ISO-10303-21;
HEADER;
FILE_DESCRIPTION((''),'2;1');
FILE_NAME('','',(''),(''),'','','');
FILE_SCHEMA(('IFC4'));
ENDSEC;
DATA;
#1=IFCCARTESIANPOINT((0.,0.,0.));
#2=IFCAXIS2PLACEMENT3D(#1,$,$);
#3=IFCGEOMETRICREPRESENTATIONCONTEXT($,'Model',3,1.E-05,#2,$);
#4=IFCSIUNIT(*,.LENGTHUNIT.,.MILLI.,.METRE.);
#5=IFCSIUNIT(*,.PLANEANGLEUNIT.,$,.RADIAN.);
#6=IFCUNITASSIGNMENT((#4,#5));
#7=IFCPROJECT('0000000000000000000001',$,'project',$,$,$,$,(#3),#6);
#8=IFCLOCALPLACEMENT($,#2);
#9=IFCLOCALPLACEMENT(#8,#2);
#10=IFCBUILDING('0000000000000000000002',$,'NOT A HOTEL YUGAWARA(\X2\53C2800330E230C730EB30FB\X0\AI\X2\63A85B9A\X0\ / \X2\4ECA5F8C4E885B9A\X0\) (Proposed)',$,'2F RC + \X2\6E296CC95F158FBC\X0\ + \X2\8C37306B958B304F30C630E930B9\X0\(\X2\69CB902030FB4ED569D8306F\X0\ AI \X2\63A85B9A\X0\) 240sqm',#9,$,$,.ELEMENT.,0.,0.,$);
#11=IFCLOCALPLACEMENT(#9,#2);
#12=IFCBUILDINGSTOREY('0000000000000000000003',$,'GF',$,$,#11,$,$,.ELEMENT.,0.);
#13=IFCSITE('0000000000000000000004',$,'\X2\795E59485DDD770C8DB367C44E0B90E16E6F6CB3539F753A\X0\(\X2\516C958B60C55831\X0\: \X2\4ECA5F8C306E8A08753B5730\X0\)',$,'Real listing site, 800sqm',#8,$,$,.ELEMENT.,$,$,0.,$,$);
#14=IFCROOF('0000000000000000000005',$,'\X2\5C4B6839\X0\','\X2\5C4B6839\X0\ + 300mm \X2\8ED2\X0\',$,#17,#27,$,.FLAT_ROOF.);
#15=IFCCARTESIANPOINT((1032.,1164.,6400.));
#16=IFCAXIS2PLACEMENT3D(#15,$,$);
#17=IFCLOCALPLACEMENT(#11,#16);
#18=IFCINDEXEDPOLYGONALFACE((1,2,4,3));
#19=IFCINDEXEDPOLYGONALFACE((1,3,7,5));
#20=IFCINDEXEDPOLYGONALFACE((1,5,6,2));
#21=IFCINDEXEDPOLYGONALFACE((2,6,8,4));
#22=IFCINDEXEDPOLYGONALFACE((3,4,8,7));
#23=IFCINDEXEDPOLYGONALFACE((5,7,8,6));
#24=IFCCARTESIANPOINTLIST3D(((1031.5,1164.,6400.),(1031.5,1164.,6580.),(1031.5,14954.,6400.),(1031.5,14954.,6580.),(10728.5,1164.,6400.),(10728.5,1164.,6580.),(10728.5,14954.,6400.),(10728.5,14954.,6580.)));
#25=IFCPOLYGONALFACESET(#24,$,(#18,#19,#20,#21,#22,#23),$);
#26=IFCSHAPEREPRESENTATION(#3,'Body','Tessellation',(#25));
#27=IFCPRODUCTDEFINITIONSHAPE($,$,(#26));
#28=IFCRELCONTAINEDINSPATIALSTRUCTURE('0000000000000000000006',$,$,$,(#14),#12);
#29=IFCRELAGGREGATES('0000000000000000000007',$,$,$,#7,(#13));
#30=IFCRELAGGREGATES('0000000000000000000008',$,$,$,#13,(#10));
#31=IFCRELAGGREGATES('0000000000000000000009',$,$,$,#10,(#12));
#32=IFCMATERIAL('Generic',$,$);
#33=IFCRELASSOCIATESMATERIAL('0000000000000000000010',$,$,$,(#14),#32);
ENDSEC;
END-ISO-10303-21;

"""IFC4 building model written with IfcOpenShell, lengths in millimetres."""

from ifc_helpers import new_model, si_unit, frame, frame_2d, origin, place, context, project, spatial, rectangle, extrude, material, element, save


model = new_model("IFC4")

# Units and contexts
model_context = context("Model", 3, precision=1e-05, world=origin())
ifc_project = project(units=[si_unit("LENGTHUNIT", "METRE", prefix="MILLI"), si_unit("PLANEANGLEUNIT", "RADIAN")], contexts=[model_context])

# Site, building, storey
site_placement = place(None, origin())
site = spatial("IfcSite", under=ifc_project, at=site_placement, Name="神奈川県足柄下郡湯河原町(公開情報: 今後の計画地)", ObjectType="Real listing site, 800sqm", CompositionType="ELEMENT", RefElevation=0.0)
building_placement = place(site_placement, origin())
building = spatial("IfcBuilding", under=site, at=building_placement, Name="NOT A HOTEL YUGAWARA(参考モデル・AI推定 / 今後予定) (Proposed)", ObjectType="2F RC + 温泉引込 + 谷に開くテラス(構造・仕様は AI 推定) 240sqm", CompositionType="ELEMENT", ElevationOfRefHeight=0.0, ElevationOfTerrain=0.0)
storey_placement = place(building_placement, origin())
storey = spatial("IfcBuildingStorey", under=building, at=storey_placement, Name="GF", CompositionType="ELEMENT", Elevation=0.0)

# Shared definitions
ifc_material_1 = material(Name="Generic")

# Roof
roof_placement = place(storey_placement, frame((1032.0, 1164.0, 6400.0)))
element("IfcRoof", 1, at=roof_placement, inside=storey, material=ifc_material_1, Name="屋根", Description="屋根 + 300mm 軒", PredefinedType="FLAT_ROOF", context=model_context, shape_type="SweptSolid", body=[
    extrude(rectangle(XDim=9697.0, YDim=13790.0, at=frame_2d((4848.0, 6895.0))), frame((1032.0, 1164.0, 6400.0)), (0.0, 0.0, 1.0), 180.0),
])

save(model, "model.ifc")
